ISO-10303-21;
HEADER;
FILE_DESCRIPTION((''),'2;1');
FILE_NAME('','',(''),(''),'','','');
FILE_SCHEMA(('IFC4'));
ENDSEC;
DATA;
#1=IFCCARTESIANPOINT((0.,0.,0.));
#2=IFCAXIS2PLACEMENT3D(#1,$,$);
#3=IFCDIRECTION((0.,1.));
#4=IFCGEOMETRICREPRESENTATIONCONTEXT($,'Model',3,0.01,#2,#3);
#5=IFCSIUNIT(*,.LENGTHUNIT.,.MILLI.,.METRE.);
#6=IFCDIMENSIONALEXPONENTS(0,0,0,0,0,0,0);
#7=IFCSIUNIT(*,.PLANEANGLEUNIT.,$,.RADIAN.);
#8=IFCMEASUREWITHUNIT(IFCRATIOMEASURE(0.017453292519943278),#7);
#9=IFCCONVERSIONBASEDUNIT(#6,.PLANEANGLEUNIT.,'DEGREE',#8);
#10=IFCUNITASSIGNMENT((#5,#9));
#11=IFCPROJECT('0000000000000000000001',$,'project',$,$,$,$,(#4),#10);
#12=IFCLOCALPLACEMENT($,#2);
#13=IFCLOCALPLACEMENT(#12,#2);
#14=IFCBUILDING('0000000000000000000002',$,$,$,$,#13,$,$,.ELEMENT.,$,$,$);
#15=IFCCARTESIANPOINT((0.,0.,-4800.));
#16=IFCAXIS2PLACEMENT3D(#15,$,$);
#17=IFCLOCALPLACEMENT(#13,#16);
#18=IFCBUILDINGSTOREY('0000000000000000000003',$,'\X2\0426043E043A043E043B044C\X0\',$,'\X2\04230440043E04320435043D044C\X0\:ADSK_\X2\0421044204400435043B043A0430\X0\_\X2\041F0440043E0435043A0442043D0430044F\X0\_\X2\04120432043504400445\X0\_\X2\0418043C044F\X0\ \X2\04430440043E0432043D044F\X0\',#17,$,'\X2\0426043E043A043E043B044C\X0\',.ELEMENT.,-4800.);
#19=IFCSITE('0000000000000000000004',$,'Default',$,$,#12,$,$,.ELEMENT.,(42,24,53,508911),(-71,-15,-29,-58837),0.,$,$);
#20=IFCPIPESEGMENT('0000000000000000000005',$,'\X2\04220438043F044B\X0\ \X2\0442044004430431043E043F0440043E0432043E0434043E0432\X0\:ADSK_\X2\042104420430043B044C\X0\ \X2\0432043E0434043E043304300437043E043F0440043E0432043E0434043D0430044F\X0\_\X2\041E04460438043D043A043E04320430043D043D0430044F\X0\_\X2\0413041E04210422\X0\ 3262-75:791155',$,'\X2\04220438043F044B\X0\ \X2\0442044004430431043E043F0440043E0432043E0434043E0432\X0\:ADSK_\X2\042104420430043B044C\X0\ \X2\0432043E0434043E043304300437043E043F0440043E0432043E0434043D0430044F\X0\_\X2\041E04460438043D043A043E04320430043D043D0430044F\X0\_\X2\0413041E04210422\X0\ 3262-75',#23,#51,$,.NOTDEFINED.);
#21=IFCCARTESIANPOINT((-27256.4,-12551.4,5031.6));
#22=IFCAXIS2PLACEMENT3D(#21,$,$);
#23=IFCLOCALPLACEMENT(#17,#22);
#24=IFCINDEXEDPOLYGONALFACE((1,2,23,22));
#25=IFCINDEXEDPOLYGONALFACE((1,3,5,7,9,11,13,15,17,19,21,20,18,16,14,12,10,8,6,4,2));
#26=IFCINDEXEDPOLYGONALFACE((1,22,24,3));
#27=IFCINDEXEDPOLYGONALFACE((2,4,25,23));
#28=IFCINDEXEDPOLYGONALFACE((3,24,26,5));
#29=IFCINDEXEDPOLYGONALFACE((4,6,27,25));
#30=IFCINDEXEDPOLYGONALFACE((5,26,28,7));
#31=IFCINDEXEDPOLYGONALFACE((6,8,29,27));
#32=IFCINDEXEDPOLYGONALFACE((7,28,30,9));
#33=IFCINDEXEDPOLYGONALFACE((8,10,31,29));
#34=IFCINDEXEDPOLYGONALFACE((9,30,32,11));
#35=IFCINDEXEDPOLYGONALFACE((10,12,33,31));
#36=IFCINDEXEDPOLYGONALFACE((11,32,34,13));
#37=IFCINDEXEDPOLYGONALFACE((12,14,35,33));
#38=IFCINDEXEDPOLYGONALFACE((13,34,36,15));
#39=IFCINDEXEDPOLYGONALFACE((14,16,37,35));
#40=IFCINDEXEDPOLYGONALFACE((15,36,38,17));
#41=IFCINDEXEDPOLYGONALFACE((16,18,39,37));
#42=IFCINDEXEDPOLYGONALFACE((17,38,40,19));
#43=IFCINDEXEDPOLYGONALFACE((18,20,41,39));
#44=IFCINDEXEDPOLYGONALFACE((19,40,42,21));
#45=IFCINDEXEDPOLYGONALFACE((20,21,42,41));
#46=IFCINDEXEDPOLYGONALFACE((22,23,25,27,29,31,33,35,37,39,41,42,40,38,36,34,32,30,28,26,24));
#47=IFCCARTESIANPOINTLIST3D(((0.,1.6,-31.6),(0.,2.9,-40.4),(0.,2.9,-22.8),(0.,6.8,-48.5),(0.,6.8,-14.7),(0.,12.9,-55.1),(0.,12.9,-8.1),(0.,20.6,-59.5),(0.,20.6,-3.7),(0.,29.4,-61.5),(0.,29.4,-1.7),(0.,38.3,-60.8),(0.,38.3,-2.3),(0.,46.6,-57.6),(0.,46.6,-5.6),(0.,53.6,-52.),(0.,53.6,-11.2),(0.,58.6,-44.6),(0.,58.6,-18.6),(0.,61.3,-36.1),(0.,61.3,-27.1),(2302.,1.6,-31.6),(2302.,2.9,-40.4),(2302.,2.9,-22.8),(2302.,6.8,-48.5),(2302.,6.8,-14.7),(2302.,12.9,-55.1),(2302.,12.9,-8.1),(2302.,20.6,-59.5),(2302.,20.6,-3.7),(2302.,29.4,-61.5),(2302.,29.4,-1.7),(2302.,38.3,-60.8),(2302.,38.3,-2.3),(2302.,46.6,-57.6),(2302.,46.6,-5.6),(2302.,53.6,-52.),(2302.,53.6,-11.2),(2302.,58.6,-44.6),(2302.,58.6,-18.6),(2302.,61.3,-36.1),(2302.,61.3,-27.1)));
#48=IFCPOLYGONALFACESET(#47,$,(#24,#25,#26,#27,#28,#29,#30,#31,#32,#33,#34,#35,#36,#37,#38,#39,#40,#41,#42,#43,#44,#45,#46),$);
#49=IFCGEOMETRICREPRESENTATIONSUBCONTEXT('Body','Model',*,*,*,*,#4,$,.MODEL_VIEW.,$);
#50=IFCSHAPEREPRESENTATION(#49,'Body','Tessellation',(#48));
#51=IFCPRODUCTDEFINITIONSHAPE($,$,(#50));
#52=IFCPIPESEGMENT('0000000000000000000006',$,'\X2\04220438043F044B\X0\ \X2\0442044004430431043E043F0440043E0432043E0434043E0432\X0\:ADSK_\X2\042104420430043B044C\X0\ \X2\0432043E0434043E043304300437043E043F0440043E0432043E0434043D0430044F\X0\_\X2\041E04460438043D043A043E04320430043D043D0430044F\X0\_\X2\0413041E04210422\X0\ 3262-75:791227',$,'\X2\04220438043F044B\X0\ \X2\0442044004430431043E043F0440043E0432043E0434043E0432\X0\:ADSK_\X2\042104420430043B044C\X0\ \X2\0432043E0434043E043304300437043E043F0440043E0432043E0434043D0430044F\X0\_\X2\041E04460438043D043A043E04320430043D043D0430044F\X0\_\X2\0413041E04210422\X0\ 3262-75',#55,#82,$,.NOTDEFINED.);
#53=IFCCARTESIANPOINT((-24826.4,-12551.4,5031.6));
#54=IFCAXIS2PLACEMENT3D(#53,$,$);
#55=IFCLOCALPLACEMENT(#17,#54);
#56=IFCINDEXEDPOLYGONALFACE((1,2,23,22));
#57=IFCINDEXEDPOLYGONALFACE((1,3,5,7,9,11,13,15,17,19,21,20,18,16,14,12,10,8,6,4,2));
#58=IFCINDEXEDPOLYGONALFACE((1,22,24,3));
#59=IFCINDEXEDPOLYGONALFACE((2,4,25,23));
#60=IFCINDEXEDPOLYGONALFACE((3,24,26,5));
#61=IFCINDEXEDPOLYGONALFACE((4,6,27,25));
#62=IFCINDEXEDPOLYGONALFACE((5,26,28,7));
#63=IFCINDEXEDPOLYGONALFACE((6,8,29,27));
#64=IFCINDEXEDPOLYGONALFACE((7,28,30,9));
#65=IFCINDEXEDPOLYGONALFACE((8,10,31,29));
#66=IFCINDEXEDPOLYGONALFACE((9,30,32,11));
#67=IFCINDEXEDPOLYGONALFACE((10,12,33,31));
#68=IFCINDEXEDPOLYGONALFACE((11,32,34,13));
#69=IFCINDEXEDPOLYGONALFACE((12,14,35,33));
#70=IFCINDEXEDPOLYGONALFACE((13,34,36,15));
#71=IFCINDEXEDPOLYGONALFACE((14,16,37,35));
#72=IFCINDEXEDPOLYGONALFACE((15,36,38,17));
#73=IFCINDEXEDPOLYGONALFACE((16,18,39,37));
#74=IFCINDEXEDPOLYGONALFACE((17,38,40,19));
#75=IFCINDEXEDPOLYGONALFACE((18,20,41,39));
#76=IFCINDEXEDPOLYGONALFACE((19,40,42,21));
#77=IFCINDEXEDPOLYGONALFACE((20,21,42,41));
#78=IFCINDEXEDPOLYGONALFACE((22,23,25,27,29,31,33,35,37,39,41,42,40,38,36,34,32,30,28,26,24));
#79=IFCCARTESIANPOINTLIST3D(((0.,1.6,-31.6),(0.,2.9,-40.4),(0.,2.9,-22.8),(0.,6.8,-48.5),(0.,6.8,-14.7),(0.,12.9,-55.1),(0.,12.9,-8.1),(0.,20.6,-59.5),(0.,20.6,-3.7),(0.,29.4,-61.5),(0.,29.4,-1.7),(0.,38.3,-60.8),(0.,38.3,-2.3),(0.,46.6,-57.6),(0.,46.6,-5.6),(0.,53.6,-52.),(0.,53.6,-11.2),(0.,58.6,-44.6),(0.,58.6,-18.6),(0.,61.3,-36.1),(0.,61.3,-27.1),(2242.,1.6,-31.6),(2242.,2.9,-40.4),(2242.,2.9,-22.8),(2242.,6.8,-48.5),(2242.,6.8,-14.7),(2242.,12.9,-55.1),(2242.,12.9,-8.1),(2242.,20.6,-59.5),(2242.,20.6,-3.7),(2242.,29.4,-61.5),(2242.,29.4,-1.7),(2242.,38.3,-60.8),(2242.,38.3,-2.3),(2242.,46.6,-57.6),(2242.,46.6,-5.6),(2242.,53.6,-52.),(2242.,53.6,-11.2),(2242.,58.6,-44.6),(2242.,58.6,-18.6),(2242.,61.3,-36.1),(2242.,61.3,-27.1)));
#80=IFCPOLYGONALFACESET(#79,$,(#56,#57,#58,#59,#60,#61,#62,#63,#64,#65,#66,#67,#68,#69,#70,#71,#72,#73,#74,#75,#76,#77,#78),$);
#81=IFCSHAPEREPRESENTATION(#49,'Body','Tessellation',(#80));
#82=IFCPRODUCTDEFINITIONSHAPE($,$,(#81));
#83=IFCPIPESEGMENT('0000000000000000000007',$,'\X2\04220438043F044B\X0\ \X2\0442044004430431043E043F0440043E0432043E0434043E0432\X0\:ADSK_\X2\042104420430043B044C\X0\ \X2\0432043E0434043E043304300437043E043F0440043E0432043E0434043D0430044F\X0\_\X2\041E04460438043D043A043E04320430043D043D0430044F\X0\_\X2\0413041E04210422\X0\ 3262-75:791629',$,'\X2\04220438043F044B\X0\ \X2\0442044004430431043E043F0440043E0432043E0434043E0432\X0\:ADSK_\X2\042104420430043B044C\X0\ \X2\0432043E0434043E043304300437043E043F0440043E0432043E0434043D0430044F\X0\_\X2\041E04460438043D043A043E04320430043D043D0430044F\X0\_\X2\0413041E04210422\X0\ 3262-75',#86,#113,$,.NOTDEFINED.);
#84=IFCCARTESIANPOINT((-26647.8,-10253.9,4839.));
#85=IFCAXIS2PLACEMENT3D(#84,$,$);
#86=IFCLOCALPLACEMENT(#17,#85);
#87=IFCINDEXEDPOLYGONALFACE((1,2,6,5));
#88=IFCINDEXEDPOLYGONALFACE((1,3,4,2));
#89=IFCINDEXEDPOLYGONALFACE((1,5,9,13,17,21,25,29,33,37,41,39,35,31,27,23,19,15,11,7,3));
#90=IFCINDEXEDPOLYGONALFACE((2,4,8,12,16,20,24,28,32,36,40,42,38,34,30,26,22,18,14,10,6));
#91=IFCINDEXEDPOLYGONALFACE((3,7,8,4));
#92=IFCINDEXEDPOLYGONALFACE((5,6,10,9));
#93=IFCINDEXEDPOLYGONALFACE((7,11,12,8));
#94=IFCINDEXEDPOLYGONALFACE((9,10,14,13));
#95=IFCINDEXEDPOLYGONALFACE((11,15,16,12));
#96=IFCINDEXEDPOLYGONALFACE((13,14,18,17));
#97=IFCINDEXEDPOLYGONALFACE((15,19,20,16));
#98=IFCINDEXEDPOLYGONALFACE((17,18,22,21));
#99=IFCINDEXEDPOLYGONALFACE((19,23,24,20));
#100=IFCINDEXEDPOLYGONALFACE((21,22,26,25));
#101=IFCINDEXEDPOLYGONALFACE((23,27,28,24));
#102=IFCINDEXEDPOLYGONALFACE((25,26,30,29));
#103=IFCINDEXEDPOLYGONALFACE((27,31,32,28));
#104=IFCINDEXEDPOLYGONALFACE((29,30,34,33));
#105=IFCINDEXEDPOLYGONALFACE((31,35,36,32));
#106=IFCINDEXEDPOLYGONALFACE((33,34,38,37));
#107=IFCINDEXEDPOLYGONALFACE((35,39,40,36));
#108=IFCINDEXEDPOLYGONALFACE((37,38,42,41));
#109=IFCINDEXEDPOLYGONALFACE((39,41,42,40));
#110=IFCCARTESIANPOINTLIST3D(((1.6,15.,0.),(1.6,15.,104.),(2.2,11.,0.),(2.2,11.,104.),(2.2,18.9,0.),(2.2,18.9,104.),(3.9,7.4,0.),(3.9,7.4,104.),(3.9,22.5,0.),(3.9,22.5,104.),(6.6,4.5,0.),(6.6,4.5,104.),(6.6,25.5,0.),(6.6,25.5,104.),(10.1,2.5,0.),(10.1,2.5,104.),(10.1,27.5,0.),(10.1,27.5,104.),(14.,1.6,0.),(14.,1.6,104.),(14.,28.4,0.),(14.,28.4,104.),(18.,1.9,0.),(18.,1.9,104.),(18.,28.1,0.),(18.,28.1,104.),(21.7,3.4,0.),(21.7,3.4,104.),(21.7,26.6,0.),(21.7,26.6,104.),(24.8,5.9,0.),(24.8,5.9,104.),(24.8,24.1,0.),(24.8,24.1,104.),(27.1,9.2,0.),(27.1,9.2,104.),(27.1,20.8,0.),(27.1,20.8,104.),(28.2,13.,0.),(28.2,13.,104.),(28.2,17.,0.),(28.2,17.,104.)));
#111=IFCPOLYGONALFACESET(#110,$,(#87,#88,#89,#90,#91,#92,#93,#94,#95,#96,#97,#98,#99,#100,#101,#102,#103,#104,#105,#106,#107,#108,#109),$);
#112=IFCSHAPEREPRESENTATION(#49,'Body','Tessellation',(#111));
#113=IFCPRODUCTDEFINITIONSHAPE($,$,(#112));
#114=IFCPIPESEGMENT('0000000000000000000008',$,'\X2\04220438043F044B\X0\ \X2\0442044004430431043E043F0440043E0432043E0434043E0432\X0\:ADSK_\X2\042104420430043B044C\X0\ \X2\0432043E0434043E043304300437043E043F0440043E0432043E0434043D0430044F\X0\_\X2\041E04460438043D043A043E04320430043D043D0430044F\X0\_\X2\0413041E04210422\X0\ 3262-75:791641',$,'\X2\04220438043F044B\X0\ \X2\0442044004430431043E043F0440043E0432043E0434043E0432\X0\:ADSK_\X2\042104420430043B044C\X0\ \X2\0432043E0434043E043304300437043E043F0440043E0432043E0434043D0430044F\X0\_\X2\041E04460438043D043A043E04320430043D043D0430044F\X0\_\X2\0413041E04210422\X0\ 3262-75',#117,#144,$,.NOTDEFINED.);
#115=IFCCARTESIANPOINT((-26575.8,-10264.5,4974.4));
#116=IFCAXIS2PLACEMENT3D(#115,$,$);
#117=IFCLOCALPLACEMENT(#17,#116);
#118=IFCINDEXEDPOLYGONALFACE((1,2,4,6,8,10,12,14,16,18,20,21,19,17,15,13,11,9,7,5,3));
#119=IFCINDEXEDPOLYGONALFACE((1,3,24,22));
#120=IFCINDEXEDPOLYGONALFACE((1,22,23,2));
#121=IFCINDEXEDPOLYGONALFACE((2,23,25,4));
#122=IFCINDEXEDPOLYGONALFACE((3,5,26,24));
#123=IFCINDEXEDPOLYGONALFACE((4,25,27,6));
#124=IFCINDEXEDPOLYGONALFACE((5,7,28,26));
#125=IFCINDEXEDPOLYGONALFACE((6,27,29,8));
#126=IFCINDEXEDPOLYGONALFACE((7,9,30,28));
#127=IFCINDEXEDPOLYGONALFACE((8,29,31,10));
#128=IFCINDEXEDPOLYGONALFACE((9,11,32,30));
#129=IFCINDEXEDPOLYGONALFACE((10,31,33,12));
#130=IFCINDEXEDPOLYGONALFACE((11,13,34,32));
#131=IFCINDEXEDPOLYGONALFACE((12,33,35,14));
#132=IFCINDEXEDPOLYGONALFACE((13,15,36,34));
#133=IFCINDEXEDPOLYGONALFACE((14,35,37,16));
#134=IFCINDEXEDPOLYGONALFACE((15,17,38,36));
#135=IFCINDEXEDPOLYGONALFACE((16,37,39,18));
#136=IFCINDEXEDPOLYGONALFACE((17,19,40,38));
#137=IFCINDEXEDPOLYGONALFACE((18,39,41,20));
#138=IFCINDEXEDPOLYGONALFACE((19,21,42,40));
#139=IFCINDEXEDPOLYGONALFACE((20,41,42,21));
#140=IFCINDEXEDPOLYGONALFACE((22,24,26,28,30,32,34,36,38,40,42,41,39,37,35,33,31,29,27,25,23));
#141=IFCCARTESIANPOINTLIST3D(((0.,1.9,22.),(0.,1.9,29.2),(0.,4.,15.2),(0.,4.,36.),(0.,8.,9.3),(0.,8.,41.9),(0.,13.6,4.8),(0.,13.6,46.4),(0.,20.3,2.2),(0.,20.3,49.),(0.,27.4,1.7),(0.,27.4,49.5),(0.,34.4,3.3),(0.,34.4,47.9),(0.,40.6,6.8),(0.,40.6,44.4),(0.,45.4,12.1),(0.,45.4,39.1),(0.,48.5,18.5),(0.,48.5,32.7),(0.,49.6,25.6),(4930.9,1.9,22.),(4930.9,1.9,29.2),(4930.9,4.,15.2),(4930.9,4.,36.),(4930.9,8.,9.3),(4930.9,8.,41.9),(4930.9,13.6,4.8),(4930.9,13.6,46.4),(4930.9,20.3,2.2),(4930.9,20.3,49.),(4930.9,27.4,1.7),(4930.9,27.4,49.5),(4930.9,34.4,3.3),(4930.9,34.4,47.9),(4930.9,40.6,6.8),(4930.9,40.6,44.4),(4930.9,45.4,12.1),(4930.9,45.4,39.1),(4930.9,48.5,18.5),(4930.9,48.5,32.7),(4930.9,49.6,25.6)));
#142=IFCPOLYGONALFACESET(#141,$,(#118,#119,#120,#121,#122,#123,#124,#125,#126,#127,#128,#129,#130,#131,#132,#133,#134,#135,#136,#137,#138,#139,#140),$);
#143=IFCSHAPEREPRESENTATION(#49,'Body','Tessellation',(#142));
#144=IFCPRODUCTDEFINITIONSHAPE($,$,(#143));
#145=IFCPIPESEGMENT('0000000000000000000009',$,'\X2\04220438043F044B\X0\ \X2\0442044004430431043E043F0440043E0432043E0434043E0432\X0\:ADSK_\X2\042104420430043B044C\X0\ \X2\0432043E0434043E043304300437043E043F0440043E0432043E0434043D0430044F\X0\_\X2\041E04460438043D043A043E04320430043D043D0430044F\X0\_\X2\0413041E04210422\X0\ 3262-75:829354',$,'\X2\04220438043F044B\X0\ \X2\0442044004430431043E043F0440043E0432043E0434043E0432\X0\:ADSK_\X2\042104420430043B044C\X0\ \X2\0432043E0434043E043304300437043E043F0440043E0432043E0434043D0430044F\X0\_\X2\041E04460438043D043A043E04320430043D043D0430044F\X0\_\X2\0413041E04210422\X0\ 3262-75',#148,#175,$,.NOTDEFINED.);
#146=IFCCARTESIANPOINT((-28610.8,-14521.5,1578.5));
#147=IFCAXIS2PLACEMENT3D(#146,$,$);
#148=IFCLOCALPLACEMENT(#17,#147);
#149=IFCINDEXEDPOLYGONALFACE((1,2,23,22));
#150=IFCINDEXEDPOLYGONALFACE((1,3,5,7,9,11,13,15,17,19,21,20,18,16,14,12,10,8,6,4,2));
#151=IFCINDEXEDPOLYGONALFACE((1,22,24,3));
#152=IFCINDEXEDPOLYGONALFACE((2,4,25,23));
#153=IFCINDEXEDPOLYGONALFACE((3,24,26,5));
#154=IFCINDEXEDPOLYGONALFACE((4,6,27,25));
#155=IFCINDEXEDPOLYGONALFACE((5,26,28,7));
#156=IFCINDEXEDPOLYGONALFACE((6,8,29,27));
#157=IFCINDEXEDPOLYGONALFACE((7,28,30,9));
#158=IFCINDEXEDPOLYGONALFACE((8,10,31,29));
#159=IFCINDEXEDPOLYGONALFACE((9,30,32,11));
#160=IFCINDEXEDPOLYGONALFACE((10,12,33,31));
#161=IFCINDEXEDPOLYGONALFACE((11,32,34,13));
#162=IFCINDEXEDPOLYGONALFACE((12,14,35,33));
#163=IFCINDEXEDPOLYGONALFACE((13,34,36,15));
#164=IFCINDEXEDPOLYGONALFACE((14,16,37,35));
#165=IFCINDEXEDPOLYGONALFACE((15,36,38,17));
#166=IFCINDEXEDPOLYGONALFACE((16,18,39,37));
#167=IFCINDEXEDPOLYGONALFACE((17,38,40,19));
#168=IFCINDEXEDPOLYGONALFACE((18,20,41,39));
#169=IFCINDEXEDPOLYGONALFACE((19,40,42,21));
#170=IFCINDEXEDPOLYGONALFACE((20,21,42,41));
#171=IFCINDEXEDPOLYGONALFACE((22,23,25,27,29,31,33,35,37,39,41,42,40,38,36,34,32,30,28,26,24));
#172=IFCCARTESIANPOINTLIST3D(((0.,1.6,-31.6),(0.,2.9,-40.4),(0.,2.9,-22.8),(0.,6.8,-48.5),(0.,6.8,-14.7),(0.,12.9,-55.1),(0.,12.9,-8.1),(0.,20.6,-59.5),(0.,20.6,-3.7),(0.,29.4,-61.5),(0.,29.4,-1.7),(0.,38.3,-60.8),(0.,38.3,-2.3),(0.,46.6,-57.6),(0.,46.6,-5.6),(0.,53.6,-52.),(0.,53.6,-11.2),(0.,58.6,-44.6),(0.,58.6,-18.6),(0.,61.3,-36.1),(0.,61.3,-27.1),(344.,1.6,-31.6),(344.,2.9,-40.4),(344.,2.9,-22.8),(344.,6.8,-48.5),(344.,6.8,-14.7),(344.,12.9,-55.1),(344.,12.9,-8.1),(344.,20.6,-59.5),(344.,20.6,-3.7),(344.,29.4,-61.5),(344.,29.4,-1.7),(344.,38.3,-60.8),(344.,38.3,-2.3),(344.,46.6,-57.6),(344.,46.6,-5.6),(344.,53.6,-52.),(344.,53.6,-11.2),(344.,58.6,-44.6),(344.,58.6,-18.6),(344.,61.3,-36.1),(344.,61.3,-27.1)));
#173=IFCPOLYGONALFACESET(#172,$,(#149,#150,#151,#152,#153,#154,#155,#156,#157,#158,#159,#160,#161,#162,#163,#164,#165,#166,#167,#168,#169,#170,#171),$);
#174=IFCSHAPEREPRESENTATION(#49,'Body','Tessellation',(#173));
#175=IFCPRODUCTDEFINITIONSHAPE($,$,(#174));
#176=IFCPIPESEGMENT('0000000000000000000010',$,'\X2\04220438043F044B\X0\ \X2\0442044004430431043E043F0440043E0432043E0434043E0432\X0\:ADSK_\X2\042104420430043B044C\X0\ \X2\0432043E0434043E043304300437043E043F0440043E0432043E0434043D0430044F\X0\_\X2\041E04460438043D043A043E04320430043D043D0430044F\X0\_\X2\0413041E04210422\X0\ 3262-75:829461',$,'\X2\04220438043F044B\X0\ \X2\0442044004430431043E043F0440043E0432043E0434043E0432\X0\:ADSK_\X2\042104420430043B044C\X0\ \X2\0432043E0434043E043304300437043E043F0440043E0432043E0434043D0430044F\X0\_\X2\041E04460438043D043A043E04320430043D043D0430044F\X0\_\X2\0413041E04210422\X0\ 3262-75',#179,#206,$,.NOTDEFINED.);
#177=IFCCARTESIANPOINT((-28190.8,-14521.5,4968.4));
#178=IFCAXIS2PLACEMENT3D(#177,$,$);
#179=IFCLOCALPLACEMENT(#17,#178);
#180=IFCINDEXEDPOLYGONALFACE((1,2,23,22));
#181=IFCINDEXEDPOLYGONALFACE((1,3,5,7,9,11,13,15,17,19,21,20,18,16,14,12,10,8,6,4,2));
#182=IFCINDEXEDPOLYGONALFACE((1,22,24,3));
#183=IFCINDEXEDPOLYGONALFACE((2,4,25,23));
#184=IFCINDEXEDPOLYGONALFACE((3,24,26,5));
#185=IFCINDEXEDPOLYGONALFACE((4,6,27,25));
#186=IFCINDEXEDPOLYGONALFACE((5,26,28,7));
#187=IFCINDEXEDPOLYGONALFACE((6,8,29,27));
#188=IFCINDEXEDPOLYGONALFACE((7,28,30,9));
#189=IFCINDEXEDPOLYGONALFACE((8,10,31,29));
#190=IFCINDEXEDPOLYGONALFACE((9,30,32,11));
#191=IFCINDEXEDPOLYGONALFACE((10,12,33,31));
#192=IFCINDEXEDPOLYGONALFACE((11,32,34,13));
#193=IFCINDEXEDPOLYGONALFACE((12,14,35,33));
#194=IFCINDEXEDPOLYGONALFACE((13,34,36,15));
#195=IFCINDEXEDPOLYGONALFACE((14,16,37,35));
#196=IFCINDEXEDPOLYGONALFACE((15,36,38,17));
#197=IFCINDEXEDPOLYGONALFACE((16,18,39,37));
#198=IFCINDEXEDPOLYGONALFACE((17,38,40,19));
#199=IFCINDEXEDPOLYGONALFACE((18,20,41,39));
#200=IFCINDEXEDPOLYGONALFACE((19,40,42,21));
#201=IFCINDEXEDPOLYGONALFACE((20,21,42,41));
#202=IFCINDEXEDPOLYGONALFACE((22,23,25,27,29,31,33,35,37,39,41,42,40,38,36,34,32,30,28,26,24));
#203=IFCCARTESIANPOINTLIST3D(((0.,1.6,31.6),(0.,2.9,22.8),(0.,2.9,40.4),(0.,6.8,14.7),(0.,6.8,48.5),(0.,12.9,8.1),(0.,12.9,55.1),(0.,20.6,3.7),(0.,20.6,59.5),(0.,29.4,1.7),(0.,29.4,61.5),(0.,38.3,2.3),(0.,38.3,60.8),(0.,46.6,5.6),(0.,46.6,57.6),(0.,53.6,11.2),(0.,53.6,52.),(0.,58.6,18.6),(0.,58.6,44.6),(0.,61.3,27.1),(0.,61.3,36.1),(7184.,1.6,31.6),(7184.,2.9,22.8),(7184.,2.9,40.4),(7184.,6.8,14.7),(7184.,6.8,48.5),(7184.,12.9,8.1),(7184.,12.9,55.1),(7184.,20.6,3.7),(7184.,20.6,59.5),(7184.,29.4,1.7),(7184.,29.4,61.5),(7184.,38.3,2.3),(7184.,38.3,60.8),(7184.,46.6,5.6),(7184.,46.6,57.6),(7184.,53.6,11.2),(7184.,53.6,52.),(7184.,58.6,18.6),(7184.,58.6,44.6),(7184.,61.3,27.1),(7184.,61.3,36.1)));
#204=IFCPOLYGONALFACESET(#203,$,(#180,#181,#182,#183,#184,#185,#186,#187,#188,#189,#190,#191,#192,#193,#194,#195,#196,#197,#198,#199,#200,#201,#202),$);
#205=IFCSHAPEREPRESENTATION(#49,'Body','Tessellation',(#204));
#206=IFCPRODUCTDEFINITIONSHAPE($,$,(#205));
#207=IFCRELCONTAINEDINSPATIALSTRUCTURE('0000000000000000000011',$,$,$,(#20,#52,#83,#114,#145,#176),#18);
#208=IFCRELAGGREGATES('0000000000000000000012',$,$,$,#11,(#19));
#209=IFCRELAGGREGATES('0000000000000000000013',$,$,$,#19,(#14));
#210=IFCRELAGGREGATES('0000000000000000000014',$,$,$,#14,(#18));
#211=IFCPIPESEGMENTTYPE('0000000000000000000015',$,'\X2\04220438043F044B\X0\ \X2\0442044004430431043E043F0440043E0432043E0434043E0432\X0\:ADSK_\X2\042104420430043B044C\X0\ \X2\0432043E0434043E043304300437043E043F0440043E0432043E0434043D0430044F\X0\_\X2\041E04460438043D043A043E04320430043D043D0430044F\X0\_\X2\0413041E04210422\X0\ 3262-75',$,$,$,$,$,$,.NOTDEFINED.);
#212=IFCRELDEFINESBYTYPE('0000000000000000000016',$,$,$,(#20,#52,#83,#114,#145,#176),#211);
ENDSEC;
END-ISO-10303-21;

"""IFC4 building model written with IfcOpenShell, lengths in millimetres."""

from ifc_helpers import new_model, entity, si_unit, converted_unit, direction, frame, frame_2d, origin, origin_2d_with_axis, place, context, subcontext, project, spatial, circle, extrude, type_object, element, save


model = new_model("IFC4")

# Units and contexts
model_context = context("Model", 3, precision=0.01, world=origin(), true_north=direction((0.0, 1.0)))
body_context = subcontext(model_context, "Body", "Model", "MODEL_VIEW")
ifc_project = project(units=[si_unit("LENGTHUNIT", "METRE", prefix="MILLI"), converted_unit("PLANEANGLEUNIT", "DEGREE", entity("IfcRatioMeasure", 0.017453292519943278), si_unit("PLANEANGLEUNIT", "RADIAN"), dimensions=[0, 0, 0, 0, 0, 0, 0])], contexts=[model_context])

# Site, building, storey
site_placement = place(None, origin())
site = spatial("IfcSite", under=ifc_project, at=site_placement, Name="Default", CompositionType="ELEMENT", RefLatitude=(42, 24, 53, 508911), RefLongitude=(-71, -15, -29, -58837), RefElevation=0.0)
building_placement = place(site_placement, origin())
building = spatial("IfcBuilding", under=site, at=building_placement, CompositionType="ELEMENT")
storey_placement = place(building_placement, frame((0.0, 0.0, -4800.0)))
storey = spatial("IfcBuildingStorey", under=building, at=storey_placement, Name="Цоколь", ObjectType="Уровень:ADSK_Стрелка_Проектная_Вверх_Имя уровня", LongName="Цоколь", CompositionType="ELEMENT", Elevation=-4800.0)

# Pipe segments
pipe_segment_type = type_object("IfcPipeSegmentType", Name="Типы трубопроводов:ADSK_Сталь водогазопроводная_Оцинкованная_ГОСТ 3262-75", PredefinedType="NOTDEFINED")
pipe_segment_1_placement = place(storey_placement, frame((-27256.4, -12551.4, 5031.6)))
element("IfcPipeSegment", 1, at=pipe_segment_1_placement, inside=storey, type_object=pipe_segment_type, Name="Типы трубопроводов:ADSK_Сталь водогазопроводная_Оцинкованная_ГОСТ 3262-75:791155", ObjectType="Типы трубопроводов:ADSK_Сталь водогазопроводная_Оцинкованная_ГОСТ 3262-75", PredefinedType="NOTDEFINED", context=body_context, shape_type="SweptSolid", body=[
    extrude(circle(Radius=30.0, at=frame_2d((0.0, 0.0), x_axis=(1.0, 0.0))), frame((0.0, 31.6, -31.6), z_axis=(1.0, 0.0, 0.0), x_axis=(0.0, -1.0, 0.0)), (0.0, 0.0, 1.0), 2302.0),
])
pipe_segment_2_placement = place(storey_placement, frame((-24826.4, -12551.4, 5031.6)))
element("IfcPipeSegment", 2, at=pipe_segment_2_placement, inside=storey, type_object=pipe_segment_type, Name="Типы трубопроводов:ADSK_Сталь водогазопроводная_Оцинкованная_ГОСТ 3262-75:791227", ObjectType="Типы трубопроводов:ADSK_Сталь водогазопроводная_Оцинкованная_ГОСТ 3262-75", PredefinedType="NOTDEFINED", context=body_context, shape_type="SweptSolid", body=[
    extrude(circle(Radius=30.0, at=frame_2d((0.0, 0.0), x_axis=(1.0, 0.0))), frame((0.0, 31.6, -31.6), z_axis=(1.0, 0.0, 0.0), x_axis=(0.0, -1.0, 0.0)), (0.0, 0.0, 1.0), 2242.0),
])
pipe_segment_3_placement = place(storey_placement, frame((-26647.8, -10253.9, 4839.0)))
element("IfcPipeSegment", 3, at=pipe_segment_3_placement, inside=storey, type_object=pipe_segment_type, Name="Типы трубопроводов:ADSK_Сталь водогазопроводная_Оцинкованная_ГОСТ 3262-75:791629", ObjectType="Типы трубопроводов:ADSK_Сталь водогазопроводная_Оцинкованная_ГОСТ 3262-75", PredefinedType="NOTDEFINED", context=body_context, shape_type="SweptSolid", body=[
    extrude(circle(Radius=13.4, at=origin_2d_with_axis()), frame((15.0, 15.0, 0.0), z_axis=(0.0, 0.0, 1.0), x_axis=(-1.0, 0.0, 0.0)), (0.0, 0.0, 1.0), 104.0),
])
pipe_segment_4_placement = place(storey_placement, frame((-26575.8, -10264.5, 4974.4)))
element("IfcPipeSegment", 4, at=pipe_segment_4_placement, inside=storey, type_object=pipe_segment_type, Name="Типы трубопроводов:ADSK_Сталь водогазопроводная_Оцинкованная_ГОСТ 3262-75:791641", ObjectType="Типы трубопроводов:ADSK_Сталь водогазопроводная_Оцинкованная_ГОСТ 3262-75", PredefinedType="NOTDEFINED", context=body_context, shape_type="SweptSolid", body=[
    extrude(circle(Radius=24.0, at=origin_2d_with_axis()), frame((0.0, 25.6, 25.6), z_axis=(1.0, 0.0, 0.0), x_axis=(0.0, 1.0, 0.0)), (0.0, 0.0, 1.0), 4930.9),
])
pipe_segment_5_placement = place(storey_placement, frame((-28610.8, -14521.5, 1578.5)))
element("IfcPipeSegment", 5, at=pipe_segment_5_placement, inside=storey, type_object=pipe_segment_type, Name="Типы трубопроводов:ADSK_Сталь водогазопроводная_Оцинкованная_ГОСТ 3262-75:829354", ObjectType="Типы трубопроводов:ADSK_Сталь водогазопроводная_Оцинкованная_ГОСТ 3262-75", PredefinedType="NOTDEFINED", context=body_context, shape_type="SweptSolid", body=[
    extrude(circle(Radius=30.0, at=frame_2d((0.0, 0.0), x_axis=(1.0, 0.0))), frame((0.0, 31.6, -31.6), z_axis=(1.0, 0.0, 0.0), x_axis=(0.0, -1.0, 0.0)), (0.0, 0.0, 1.0), 344.0),
])
pipe_segment_6_placement = place(storey_placement, frame((-28190.8, -14521.5, 4968.4)))
element("IfcPipeSegment", 6, at=pipe_segment_6_placement, inside=storey, type_object=pipe_segment_type, Name="Типы трубопроводов:ADSK_Сталь водогазопроводная_Оцинкованная_ГОСТ 3262-75:829461", ObjectType="Типы трубопроводов:ADSK_Сталь водогазопроводная_Оцинкованная_ГОСТ 3262-75", PredefinedType="NOTDEFINED", context=body_context, shape_type="SweptSolid", body=[
    extrude(circle(Radius=30.0, at=frame_2d((0.0, 0.0), x_axis=(1.0, 0.0))), frame((0.0, 31.6, 31.6), z_axis=(1.0, 0.0, 0.0), x_axis=(0.0, -1.0, 0.0)), (0.0, 0.0, 1.0), 7184.0),
])

save(model, "model.ifc")
